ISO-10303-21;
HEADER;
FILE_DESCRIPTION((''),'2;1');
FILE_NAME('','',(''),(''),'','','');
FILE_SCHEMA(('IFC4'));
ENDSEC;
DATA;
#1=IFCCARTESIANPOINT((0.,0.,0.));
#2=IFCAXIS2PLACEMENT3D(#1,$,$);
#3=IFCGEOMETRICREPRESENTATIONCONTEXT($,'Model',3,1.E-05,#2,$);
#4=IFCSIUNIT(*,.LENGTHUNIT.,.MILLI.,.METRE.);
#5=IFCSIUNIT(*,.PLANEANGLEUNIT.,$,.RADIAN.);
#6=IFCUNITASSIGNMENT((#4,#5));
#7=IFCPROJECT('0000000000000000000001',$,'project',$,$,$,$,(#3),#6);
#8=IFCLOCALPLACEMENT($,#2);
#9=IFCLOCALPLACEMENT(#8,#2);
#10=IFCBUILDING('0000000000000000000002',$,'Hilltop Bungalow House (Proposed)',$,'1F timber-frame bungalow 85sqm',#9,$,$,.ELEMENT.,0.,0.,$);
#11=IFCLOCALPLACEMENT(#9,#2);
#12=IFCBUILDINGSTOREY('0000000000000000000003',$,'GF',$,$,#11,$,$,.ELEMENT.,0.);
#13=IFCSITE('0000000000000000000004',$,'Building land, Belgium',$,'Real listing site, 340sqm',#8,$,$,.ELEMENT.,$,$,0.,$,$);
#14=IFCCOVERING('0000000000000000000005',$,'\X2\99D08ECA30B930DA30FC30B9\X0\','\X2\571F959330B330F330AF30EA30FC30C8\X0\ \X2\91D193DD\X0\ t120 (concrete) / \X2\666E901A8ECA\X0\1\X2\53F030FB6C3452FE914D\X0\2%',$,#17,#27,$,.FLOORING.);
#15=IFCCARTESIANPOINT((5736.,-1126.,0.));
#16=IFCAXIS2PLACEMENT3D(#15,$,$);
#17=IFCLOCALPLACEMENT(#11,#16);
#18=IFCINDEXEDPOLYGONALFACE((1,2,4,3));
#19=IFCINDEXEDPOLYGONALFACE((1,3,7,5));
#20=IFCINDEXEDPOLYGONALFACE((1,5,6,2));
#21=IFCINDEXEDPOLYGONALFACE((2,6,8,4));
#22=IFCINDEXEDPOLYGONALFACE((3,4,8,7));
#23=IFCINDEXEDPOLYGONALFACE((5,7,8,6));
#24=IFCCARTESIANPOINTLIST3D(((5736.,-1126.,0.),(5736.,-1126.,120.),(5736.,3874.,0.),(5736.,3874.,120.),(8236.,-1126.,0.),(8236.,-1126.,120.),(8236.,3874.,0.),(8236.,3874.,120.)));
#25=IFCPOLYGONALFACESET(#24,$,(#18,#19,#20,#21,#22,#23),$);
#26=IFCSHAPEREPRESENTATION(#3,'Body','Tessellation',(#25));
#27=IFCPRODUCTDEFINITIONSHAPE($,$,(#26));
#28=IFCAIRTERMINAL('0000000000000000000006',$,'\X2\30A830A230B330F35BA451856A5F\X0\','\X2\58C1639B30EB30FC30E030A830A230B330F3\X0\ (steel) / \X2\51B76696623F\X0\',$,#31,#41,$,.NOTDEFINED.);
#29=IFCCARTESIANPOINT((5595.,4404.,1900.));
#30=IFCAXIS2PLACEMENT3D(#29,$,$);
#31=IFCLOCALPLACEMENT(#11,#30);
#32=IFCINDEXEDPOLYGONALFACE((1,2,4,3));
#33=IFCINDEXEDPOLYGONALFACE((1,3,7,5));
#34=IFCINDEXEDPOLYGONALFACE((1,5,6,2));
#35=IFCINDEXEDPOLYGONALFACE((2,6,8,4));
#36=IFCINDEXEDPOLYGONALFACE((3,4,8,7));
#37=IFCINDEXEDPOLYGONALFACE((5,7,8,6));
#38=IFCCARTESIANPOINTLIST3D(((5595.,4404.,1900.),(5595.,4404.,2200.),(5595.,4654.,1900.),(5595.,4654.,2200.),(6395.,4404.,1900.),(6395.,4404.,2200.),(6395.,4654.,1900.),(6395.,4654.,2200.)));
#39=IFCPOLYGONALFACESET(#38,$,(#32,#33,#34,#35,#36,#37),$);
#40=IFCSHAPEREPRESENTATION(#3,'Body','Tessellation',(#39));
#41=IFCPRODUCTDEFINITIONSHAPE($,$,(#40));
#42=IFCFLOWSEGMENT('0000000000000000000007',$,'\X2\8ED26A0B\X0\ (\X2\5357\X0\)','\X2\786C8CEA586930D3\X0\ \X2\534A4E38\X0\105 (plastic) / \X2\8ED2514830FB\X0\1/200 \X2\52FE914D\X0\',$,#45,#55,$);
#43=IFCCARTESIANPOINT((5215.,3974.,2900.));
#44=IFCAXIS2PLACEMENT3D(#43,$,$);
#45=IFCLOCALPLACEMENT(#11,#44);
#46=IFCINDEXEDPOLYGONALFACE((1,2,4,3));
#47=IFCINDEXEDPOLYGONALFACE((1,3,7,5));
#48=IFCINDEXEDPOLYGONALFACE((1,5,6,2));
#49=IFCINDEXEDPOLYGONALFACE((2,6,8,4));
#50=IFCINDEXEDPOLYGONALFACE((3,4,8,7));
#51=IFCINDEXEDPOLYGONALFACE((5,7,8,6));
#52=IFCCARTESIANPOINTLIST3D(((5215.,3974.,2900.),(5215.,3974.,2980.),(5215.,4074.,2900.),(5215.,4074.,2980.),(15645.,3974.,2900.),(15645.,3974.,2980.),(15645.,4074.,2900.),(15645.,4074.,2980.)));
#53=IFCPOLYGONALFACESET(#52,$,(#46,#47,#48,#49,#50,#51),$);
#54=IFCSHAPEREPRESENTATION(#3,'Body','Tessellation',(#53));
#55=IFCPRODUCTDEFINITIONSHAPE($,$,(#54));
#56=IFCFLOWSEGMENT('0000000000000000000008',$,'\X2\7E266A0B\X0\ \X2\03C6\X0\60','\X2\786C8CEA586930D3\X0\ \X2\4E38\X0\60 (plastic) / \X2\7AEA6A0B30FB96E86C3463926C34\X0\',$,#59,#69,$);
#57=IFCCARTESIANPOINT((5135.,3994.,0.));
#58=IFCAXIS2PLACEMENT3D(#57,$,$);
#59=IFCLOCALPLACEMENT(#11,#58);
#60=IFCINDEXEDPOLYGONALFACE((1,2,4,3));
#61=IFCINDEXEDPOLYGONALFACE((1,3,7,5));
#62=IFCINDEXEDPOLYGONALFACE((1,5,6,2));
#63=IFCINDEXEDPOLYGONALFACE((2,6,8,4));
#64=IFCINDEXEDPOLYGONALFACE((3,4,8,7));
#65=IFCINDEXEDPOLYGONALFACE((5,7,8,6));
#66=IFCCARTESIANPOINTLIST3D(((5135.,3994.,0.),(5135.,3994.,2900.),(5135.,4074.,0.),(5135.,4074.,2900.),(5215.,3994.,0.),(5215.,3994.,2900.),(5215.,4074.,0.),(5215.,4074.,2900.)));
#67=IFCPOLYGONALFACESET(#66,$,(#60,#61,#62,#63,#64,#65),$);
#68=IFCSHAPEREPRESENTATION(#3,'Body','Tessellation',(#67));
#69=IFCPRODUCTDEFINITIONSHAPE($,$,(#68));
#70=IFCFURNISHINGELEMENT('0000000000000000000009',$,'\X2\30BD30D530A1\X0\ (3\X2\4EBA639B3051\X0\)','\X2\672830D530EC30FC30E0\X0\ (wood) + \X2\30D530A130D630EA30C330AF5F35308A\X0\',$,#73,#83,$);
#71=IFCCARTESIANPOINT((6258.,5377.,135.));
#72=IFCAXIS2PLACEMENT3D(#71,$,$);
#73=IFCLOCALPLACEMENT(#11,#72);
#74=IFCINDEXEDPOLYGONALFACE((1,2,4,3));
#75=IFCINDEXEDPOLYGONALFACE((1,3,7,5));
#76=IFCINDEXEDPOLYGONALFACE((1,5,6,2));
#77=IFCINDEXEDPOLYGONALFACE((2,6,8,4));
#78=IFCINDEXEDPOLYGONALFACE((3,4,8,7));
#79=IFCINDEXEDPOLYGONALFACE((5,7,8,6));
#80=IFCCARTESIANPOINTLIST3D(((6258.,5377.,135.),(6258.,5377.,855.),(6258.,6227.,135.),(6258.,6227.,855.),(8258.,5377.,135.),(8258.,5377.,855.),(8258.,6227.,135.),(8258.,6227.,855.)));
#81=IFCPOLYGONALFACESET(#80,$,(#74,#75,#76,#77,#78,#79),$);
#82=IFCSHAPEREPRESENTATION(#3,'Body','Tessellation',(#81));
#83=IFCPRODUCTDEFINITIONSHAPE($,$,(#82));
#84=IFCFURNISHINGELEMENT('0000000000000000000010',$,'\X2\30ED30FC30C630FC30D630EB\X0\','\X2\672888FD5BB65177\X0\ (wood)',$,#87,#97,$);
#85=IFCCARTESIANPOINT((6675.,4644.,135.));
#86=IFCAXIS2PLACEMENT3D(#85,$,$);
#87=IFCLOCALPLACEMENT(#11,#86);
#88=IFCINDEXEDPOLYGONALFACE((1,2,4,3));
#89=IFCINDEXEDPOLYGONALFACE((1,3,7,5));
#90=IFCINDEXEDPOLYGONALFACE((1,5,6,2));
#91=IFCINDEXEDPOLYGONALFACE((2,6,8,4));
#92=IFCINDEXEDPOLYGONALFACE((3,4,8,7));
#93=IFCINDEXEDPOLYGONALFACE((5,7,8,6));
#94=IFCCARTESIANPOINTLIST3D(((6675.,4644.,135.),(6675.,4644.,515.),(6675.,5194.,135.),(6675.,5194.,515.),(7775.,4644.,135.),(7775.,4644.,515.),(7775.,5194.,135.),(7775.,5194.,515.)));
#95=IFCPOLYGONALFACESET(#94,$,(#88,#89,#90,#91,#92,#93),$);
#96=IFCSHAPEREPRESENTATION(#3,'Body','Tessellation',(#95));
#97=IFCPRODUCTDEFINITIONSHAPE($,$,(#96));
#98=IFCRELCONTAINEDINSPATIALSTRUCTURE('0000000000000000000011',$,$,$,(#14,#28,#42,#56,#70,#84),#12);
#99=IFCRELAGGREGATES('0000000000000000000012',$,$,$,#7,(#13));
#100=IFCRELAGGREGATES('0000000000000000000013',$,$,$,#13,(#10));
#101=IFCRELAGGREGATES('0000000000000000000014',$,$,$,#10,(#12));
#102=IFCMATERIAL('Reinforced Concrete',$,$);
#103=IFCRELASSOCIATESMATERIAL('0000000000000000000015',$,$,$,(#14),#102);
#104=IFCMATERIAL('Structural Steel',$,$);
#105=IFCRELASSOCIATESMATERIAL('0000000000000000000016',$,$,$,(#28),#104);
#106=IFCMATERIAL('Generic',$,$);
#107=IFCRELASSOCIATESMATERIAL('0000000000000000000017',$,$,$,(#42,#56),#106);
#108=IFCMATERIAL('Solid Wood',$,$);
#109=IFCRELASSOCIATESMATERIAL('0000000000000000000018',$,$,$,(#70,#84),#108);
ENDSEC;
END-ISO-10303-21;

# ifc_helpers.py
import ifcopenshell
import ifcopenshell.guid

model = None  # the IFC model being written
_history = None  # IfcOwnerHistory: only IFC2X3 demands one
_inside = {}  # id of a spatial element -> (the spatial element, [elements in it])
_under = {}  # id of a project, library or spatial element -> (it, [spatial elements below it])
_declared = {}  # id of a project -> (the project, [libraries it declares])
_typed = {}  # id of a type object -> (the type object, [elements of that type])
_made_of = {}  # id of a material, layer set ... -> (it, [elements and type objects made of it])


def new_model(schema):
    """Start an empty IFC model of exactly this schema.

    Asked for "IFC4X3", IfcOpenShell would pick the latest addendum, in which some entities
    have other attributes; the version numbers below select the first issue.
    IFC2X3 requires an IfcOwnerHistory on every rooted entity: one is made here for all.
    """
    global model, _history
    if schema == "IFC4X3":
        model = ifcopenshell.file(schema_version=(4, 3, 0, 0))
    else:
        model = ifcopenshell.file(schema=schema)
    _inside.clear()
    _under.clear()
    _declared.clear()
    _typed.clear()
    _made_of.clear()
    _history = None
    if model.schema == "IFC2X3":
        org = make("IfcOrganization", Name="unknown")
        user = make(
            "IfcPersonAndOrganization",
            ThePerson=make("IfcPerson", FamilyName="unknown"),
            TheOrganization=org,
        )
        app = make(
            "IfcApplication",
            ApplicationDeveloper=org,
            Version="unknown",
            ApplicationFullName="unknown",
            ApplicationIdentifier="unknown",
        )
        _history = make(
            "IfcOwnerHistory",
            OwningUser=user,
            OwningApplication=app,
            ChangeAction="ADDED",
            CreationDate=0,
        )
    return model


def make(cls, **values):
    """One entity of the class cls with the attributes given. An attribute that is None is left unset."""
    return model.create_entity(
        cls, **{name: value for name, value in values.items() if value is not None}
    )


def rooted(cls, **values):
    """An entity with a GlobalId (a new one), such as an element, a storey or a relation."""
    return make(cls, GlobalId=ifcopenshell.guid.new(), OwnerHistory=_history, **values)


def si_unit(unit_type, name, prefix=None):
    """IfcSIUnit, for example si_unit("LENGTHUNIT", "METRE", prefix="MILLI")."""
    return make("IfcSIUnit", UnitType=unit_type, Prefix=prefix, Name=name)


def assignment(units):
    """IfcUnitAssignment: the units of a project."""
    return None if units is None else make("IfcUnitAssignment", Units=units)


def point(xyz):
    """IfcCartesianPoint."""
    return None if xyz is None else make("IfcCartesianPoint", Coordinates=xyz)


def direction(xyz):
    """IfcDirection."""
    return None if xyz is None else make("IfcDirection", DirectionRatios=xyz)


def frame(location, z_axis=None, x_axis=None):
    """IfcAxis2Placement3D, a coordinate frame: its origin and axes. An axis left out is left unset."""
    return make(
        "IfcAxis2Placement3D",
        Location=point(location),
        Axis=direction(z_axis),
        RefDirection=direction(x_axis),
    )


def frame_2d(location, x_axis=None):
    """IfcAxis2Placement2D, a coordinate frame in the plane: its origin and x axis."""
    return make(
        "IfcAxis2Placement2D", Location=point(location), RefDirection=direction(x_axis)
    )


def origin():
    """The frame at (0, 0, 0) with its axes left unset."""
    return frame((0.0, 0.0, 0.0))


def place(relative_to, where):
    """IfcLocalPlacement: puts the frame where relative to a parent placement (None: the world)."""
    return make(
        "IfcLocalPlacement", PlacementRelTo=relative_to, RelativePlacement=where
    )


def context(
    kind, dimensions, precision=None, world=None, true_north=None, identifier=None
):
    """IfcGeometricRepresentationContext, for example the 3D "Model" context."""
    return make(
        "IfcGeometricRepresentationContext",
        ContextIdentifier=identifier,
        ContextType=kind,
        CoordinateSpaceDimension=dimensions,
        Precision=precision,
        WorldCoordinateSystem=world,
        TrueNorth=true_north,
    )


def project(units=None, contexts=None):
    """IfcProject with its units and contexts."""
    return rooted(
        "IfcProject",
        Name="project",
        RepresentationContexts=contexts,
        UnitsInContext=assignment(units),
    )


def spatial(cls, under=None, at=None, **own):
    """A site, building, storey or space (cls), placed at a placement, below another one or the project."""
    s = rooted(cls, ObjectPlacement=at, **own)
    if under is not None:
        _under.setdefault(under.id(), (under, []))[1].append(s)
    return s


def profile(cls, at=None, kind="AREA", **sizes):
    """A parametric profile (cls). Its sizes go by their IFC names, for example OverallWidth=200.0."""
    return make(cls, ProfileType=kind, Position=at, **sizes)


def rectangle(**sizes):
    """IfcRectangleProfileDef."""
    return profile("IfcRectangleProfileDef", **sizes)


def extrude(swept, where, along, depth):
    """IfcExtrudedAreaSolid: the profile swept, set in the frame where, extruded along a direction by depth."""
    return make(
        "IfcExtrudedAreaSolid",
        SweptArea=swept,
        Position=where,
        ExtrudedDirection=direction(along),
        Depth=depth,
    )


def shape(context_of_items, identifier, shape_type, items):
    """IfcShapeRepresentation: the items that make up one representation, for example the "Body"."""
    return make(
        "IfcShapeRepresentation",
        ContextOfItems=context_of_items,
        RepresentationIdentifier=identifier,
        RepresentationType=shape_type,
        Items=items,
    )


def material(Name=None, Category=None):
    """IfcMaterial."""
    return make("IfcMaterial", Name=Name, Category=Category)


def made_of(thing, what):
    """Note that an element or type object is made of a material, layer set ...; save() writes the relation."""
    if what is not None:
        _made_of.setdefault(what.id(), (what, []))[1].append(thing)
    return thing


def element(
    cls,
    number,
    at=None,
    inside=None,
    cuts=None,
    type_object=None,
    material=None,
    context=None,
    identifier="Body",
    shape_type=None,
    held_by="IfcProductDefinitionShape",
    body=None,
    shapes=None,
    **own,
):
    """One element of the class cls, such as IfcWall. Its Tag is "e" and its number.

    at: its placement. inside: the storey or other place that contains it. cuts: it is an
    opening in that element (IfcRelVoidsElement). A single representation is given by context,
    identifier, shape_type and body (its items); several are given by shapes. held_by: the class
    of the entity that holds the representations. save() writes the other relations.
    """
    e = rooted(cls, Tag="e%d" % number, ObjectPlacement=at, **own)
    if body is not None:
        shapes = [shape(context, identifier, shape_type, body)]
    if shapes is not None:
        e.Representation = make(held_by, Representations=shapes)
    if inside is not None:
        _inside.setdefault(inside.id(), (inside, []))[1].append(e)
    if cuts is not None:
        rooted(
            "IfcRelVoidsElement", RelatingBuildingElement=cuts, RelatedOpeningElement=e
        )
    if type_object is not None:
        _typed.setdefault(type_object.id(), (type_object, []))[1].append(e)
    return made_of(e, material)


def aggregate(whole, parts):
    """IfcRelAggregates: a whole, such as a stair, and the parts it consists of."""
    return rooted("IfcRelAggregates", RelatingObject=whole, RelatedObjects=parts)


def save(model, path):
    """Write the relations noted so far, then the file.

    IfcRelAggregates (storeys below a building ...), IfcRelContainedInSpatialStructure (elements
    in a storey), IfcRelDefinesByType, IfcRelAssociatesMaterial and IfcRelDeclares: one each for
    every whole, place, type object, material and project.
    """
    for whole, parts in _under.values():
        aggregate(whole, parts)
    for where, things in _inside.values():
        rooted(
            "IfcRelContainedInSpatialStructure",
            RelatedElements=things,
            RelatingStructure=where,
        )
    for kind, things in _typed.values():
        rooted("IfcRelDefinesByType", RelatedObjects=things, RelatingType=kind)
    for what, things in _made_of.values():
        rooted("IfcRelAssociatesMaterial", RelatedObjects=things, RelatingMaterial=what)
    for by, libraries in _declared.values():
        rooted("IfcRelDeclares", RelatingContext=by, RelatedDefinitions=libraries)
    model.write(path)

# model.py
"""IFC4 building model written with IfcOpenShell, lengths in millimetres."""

from ifc_helpers import new_model, si_unit, frame, frame_2d, origin, place, context, project, spatial, rectangle, extrude, material, element, save


model = new_model("IFC4")

# Units and contexts
model_context = context("Model", 3, precision=1e-05, world=origin())
ifc_project = project(units=[si_unit("LENGTHUNIT", "METRE", prefix="MILLI"), si_unit("PLANEANGLEUNIT", "RADIAN")], contexts=[model_context])

# Site, building, storey
site_placement = place(None, origin())
site = spatial("IfcSite", under=ifc_project, at=site_placement, Name="Building land, Belgium", ObjectType="Real listing site, 340sqm", CompositionType="ELEMENT", RefElevation=0.0)
building_placement = place(site_placement, origin())
building = spatial("IfcBuilding", under=site, at=building_placement, Name="Hilltop Bungalow House (Proposed)", ObjectType="1F timber-frame bungalow 85sqm", CompositionType="ELEMENT", ElevationOfRefHeight=0.0, ElevationOfTerrain=0.0)
storey_placement = place(building_placement, origin())
storey = spatial("IfcBuildingStorey", under=building, at=storey_placement, Name="GF", CompositionType="ELEMENT", Elevation=0.0)

# Shared definitions
ifc_material_1 = material(Name="Solid Wood")

# Shared definitions
ifc_material_2 = material(Name="Reinforced Concrete")

# Shared definitions
ifc_material_3 = material(Name="Structural Steel")

# Covering
ifc_material_4 = material(Name="Generic")
covering_1_placement = place(storey_placement, frame((5736.0, -1126.0, 0.0)))
element("IfcCovering", 1, at=covering_1_placement, inside=storey, material=ifc_material_2, Name="駐車スペース", Description="土間コンクリート 金鏝 t120 (concrete) / 普通車1台・水勾配2%", PredefinedType="FLOORING", context=model_context, shape_type="SweptSolid", body=[
    extrude(rectangle(XDim=2500.0, YDim=5000.0, at=frame_2d((1250.0, 2500.0))), frame((5736.0, -1126.0, 0.0)), (0.0, 0.0, 1.0), 120.0),
])

# Air terminal
air_terminal_placement = place(storey_placement, frame((5595.0, 4404.0, 1900.0)))
element("IfcAirTerminal", 2, at=air_terminal_placement, inside=storey, material=ifc_material_3, Name="エアコン室内機", Description="壁掛ルームエアコン (steel) / 冷暖房", PredefinedType="NOTDEFINED", context=model_context, shape_type="SweptSolid", body=[
    extrude(rectangle(XDim=800.0, YDim=250.0, at=frame_2d((400.0, 125.0))), frame((5595.0, 4404.0, 1900.0)), (0.0, 0.0, 1.0), 300.0),
])

# Flow segments
flow_segment_1_placement = place(storey_placement, frame((5215.0, 3974.0, 2900.0)))
element("IfcFlowSegment", 3, at=flow_segment_1_placement, inside=storey, material=ifc_material_4, Name="軒樋 (南)", Description="硬質塩ビ 半丸105 (plastic) / 軒先・1/200 勾配", context=model_context, shape_type="SweptSolid", body=[
    extrude(rectangle(XDim=10430.0, YDim=100.0, at=frame_2d((5215.0, 50.0))), frame((5215.0, 3974.0, 2900.0)), (0.0, 0.0, 1.0), 80.0),
])
flow_segment_2_placement = place(storey_placement, frame((5135.0, 3994.0, 0.0)))
element("IfcFlowSegment", 4, at=flow_segment_2_placement, inside=storey, material=ifc_material_4, Name="縦樋 φ60", Description="硬質塩ビ 丸60 (plastic) / 竪樋・雨水排水", context=model_context, shape_type="SweptSolid", body=[
    extrude(rectangle(XDim=80.0, YDim=80.0, at=frame_2d((40.0, 40.0))), frame((5135.0, 3994.0, 0.0)), (0.0, 0.0, 1.0), 2900.0),
])

# Furnishing elements
furnishing_1_placement = place(storey_placement, frame((6258.0, 5377.0, 135.0)))
element("IfcFurnishingElement", 5, at=furnishing_1_placement, inside=storey, material=ifc_material_1, Name="ソファ (3人掛け)", Description="木フレーム (wood) + ファブリック張り", context=model_context, shape_type="SweptSolid", body=[
    extrude(rectangle(XDim=2000.0, YDim=850.0, at=frame_2d((1000.0, 425.0))), frame((6258.0, 5377.0, 135.0)), (0.0, 0.0, 1.0), 720.0),
])
furnishing_2_placement = place(storey_placement, frame((6675.0, 4644.0, 135.0)))
element("IfcFurnishingElement", 6, at=furnishing_2_placement, inside=storey, material=ifc_material_1, Name="ローテーブル", Description="木製家具 (wood)", context=model_context, shape_type="SweptSolid", body=[
    extrude(rectangle(XDim=1100.0, YDim=550.0, at=frame_2d((550.0, 275.0))), frame((6675.0, 4644.0, 135.0)), (0.0, 0.0, 1.0), 380.0),
])

save(model, "model.ifc")
